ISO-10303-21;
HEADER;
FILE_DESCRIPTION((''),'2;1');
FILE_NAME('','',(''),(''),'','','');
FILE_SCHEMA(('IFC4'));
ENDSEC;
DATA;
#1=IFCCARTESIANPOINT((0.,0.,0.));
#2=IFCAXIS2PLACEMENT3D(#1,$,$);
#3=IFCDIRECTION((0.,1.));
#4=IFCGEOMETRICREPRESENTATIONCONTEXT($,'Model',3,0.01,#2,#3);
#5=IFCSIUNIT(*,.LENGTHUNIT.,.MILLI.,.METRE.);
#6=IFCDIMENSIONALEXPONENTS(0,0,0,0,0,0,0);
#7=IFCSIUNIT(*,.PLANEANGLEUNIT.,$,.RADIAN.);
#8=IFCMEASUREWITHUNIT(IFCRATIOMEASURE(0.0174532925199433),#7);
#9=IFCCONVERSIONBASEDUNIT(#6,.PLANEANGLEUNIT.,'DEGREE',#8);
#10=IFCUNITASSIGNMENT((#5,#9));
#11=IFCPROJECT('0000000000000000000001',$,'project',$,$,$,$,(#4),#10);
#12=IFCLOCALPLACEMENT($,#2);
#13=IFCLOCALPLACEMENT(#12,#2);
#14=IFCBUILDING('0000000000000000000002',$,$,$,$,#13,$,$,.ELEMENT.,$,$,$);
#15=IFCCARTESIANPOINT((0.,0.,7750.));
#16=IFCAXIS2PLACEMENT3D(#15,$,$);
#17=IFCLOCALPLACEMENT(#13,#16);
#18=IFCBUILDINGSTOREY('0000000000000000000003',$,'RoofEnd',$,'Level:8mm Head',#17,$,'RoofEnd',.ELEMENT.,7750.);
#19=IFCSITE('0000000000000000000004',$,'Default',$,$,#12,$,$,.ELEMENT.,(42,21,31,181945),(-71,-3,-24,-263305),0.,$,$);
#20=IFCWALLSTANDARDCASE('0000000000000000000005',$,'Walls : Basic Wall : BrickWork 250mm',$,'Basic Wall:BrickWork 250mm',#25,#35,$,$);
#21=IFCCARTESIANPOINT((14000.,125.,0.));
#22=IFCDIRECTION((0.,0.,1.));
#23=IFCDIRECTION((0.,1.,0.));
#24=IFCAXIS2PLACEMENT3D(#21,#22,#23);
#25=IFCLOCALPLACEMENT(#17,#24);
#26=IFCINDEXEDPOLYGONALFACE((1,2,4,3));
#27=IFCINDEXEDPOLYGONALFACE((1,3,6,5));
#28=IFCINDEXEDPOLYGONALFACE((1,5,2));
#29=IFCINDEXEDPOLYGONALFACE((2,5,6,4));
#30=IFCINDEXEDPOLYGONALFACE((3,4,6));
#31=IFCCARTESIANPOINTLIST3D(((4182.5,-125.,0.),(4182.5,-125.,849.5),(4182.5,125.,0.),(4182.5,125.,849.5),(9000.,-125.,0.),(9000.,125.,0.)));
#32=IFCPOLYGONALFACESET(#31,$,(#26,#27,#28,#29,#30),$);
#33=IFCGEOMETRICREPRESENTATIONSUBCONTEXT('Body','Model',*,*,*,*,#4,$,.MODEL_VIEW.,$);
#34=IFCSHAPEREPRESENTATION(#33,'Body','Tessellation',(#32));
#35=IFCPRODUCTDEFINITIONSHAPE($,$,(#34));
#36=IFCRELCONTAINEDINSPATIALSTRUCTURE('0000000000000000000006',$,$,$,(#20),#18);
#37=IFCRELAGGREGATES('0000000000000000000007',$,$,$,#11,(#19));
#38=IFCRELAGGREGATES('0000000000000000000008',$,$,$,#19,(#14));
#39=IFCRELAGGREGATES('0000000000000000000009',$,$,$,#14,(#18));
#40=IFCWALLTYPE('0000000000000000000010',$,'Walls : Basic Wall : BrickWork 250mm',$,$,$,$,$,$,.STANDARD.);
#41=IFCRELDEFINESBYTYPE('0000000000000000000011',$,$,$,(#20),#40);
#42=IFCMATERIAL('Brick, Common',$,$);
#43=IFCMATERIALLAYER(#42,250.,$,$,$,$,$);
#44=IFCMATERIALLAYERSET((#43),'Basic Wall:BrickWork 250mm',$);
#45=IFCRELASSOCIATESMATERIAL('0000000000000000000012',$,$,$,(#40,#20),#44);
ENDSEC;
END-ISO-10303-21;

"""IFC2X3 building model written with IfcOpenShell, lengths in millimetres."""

from ifc_helpers import new_model, entity, si_unit, converted_unit, direction, frame, frame_2d, origin, place, context, subcontext, project, spatial, polyline, rectangle, extrude, clip, halfspace, bounded_halfspace, material, layer, layer_set, layer_usage, type_object, element, save


model = new_model("IFC2X3")

# Units and contexts
model_context = context("Model", 3, precision=0.01, world=origin(), true_north=direction((0.0, 1.0)))
body_context = subcontext(model_context, "Body", "Model", "MODEL_VIEW")
ifc_project = project(units=[si_unit("LENGTHUNIT", "METRE", prefix="MILLI"), converted_unit("PLANEANGLEUNIT", "DEGREE", entity("IfcRatioMeasure", 0.0174532925199433), si_unit("PLANEANGLEUNIT", "RADIAN"), dimensions=[0, 0, 0, 0, 0, 0, 0])], contexts=[model_context])

# Site, building, storey
site_placement = place(None, origin())
site = spatial("IfcSite", under=ifc_project, at=site_placement, Name="Default", CompositionType="ELEMENT", RefLatitude=(42, 21, 31, 181945), RefLongitude=(-71, -3, -24, -263305), RefElevation=0.0)
building_placement = place(site_placement, origin())
building = spatial("IfcBuilding", under=site, at=building_placement, CompositionType="ELEMENT")
storey_placement = place(building_placement, frame((0.0, 0.0, 7750.0)))
storey = spatial("IfcBuildingStorey", under=building, at=storey_placement, Name="RoofEnd", ObjectType="Level:8mm Head", LongName="RoofEnd", CompositionType="ELEMENT", Elevation=7750.0)

# Wall
ifc_material = material(Name="Brick, Common")
ifc_layer = layer(ifc_material, 250.0)
ifc_layer_set = layer_set([ifc_layer], Name="Basic Wall:BrickWork 250mm")
ifc_layer_usage_1 = layer_usage(ifc_layer_set, "AXIS2", "POSITIVE", -125.0)
wall_type = type_object("IfcWallType", Name="Walls : Basic Wall : BrickWork 250mm", PredefinedType="STANDARD", material=ifc_layer_set)
wall_1_placement = place(storey_placement, frame((14000.0, 125.0, 0.0), z_axis=(0.0, 0.0, 1.0), x_axis=(0.0, 1.0, 0.0)))
element("IfcWallStandardCase", 1, at=wall_1_placement, inside=storey, type_object=wall_type, material=ifc_layer_usage_1, Name="Walls : Basic Wall : BrickWork 250mm", ObjectType="Basic Wall:BrickWork 250mm", context=body_context, shape_type="Clipping", body=[
    clip(clip(clip(extrude(rectangle(XDim=9000.0, YDim=250.0, at=frame_2d((4500.0, 0.0), x_axis=(-1.0, 0.0))), origin(), (0.0, 0.0, 1.0), 849.5), bounded_halfspace(frame((4182.5, -125.0, 849.5), z_axis=(0.173648, 0.0, 0.984808), x_axis=(0.0, 1.0, 0.0)), False, frame((4182.5, -125.0, 849.5)), polyline([(0.0, 0.0), (4817.5, 0.0), (4817.5, 250.0), (4567.5, 250.0), (282.5, 250.0), (32.5, 250.0), (0.0, 250.0), (0.0, 0.0)]))), bounded_halfspace(frame((0.0, 125.0, 0.0), z_axis=(0.0, 0.0, 1.0), x_axis=(0.0, 1.0, 0.0)), False, frame((0.0, 125.0, 0.0)), polyline([(0.0, 0.0), (0.0, -250.0), (4182.5, -250.0), (4182.5, 0.0), (0.0, 0.0)]))), halfspace(frame((0.0, 0.0, -7300.0)), True)),
])

save(model, "model.ifc")
